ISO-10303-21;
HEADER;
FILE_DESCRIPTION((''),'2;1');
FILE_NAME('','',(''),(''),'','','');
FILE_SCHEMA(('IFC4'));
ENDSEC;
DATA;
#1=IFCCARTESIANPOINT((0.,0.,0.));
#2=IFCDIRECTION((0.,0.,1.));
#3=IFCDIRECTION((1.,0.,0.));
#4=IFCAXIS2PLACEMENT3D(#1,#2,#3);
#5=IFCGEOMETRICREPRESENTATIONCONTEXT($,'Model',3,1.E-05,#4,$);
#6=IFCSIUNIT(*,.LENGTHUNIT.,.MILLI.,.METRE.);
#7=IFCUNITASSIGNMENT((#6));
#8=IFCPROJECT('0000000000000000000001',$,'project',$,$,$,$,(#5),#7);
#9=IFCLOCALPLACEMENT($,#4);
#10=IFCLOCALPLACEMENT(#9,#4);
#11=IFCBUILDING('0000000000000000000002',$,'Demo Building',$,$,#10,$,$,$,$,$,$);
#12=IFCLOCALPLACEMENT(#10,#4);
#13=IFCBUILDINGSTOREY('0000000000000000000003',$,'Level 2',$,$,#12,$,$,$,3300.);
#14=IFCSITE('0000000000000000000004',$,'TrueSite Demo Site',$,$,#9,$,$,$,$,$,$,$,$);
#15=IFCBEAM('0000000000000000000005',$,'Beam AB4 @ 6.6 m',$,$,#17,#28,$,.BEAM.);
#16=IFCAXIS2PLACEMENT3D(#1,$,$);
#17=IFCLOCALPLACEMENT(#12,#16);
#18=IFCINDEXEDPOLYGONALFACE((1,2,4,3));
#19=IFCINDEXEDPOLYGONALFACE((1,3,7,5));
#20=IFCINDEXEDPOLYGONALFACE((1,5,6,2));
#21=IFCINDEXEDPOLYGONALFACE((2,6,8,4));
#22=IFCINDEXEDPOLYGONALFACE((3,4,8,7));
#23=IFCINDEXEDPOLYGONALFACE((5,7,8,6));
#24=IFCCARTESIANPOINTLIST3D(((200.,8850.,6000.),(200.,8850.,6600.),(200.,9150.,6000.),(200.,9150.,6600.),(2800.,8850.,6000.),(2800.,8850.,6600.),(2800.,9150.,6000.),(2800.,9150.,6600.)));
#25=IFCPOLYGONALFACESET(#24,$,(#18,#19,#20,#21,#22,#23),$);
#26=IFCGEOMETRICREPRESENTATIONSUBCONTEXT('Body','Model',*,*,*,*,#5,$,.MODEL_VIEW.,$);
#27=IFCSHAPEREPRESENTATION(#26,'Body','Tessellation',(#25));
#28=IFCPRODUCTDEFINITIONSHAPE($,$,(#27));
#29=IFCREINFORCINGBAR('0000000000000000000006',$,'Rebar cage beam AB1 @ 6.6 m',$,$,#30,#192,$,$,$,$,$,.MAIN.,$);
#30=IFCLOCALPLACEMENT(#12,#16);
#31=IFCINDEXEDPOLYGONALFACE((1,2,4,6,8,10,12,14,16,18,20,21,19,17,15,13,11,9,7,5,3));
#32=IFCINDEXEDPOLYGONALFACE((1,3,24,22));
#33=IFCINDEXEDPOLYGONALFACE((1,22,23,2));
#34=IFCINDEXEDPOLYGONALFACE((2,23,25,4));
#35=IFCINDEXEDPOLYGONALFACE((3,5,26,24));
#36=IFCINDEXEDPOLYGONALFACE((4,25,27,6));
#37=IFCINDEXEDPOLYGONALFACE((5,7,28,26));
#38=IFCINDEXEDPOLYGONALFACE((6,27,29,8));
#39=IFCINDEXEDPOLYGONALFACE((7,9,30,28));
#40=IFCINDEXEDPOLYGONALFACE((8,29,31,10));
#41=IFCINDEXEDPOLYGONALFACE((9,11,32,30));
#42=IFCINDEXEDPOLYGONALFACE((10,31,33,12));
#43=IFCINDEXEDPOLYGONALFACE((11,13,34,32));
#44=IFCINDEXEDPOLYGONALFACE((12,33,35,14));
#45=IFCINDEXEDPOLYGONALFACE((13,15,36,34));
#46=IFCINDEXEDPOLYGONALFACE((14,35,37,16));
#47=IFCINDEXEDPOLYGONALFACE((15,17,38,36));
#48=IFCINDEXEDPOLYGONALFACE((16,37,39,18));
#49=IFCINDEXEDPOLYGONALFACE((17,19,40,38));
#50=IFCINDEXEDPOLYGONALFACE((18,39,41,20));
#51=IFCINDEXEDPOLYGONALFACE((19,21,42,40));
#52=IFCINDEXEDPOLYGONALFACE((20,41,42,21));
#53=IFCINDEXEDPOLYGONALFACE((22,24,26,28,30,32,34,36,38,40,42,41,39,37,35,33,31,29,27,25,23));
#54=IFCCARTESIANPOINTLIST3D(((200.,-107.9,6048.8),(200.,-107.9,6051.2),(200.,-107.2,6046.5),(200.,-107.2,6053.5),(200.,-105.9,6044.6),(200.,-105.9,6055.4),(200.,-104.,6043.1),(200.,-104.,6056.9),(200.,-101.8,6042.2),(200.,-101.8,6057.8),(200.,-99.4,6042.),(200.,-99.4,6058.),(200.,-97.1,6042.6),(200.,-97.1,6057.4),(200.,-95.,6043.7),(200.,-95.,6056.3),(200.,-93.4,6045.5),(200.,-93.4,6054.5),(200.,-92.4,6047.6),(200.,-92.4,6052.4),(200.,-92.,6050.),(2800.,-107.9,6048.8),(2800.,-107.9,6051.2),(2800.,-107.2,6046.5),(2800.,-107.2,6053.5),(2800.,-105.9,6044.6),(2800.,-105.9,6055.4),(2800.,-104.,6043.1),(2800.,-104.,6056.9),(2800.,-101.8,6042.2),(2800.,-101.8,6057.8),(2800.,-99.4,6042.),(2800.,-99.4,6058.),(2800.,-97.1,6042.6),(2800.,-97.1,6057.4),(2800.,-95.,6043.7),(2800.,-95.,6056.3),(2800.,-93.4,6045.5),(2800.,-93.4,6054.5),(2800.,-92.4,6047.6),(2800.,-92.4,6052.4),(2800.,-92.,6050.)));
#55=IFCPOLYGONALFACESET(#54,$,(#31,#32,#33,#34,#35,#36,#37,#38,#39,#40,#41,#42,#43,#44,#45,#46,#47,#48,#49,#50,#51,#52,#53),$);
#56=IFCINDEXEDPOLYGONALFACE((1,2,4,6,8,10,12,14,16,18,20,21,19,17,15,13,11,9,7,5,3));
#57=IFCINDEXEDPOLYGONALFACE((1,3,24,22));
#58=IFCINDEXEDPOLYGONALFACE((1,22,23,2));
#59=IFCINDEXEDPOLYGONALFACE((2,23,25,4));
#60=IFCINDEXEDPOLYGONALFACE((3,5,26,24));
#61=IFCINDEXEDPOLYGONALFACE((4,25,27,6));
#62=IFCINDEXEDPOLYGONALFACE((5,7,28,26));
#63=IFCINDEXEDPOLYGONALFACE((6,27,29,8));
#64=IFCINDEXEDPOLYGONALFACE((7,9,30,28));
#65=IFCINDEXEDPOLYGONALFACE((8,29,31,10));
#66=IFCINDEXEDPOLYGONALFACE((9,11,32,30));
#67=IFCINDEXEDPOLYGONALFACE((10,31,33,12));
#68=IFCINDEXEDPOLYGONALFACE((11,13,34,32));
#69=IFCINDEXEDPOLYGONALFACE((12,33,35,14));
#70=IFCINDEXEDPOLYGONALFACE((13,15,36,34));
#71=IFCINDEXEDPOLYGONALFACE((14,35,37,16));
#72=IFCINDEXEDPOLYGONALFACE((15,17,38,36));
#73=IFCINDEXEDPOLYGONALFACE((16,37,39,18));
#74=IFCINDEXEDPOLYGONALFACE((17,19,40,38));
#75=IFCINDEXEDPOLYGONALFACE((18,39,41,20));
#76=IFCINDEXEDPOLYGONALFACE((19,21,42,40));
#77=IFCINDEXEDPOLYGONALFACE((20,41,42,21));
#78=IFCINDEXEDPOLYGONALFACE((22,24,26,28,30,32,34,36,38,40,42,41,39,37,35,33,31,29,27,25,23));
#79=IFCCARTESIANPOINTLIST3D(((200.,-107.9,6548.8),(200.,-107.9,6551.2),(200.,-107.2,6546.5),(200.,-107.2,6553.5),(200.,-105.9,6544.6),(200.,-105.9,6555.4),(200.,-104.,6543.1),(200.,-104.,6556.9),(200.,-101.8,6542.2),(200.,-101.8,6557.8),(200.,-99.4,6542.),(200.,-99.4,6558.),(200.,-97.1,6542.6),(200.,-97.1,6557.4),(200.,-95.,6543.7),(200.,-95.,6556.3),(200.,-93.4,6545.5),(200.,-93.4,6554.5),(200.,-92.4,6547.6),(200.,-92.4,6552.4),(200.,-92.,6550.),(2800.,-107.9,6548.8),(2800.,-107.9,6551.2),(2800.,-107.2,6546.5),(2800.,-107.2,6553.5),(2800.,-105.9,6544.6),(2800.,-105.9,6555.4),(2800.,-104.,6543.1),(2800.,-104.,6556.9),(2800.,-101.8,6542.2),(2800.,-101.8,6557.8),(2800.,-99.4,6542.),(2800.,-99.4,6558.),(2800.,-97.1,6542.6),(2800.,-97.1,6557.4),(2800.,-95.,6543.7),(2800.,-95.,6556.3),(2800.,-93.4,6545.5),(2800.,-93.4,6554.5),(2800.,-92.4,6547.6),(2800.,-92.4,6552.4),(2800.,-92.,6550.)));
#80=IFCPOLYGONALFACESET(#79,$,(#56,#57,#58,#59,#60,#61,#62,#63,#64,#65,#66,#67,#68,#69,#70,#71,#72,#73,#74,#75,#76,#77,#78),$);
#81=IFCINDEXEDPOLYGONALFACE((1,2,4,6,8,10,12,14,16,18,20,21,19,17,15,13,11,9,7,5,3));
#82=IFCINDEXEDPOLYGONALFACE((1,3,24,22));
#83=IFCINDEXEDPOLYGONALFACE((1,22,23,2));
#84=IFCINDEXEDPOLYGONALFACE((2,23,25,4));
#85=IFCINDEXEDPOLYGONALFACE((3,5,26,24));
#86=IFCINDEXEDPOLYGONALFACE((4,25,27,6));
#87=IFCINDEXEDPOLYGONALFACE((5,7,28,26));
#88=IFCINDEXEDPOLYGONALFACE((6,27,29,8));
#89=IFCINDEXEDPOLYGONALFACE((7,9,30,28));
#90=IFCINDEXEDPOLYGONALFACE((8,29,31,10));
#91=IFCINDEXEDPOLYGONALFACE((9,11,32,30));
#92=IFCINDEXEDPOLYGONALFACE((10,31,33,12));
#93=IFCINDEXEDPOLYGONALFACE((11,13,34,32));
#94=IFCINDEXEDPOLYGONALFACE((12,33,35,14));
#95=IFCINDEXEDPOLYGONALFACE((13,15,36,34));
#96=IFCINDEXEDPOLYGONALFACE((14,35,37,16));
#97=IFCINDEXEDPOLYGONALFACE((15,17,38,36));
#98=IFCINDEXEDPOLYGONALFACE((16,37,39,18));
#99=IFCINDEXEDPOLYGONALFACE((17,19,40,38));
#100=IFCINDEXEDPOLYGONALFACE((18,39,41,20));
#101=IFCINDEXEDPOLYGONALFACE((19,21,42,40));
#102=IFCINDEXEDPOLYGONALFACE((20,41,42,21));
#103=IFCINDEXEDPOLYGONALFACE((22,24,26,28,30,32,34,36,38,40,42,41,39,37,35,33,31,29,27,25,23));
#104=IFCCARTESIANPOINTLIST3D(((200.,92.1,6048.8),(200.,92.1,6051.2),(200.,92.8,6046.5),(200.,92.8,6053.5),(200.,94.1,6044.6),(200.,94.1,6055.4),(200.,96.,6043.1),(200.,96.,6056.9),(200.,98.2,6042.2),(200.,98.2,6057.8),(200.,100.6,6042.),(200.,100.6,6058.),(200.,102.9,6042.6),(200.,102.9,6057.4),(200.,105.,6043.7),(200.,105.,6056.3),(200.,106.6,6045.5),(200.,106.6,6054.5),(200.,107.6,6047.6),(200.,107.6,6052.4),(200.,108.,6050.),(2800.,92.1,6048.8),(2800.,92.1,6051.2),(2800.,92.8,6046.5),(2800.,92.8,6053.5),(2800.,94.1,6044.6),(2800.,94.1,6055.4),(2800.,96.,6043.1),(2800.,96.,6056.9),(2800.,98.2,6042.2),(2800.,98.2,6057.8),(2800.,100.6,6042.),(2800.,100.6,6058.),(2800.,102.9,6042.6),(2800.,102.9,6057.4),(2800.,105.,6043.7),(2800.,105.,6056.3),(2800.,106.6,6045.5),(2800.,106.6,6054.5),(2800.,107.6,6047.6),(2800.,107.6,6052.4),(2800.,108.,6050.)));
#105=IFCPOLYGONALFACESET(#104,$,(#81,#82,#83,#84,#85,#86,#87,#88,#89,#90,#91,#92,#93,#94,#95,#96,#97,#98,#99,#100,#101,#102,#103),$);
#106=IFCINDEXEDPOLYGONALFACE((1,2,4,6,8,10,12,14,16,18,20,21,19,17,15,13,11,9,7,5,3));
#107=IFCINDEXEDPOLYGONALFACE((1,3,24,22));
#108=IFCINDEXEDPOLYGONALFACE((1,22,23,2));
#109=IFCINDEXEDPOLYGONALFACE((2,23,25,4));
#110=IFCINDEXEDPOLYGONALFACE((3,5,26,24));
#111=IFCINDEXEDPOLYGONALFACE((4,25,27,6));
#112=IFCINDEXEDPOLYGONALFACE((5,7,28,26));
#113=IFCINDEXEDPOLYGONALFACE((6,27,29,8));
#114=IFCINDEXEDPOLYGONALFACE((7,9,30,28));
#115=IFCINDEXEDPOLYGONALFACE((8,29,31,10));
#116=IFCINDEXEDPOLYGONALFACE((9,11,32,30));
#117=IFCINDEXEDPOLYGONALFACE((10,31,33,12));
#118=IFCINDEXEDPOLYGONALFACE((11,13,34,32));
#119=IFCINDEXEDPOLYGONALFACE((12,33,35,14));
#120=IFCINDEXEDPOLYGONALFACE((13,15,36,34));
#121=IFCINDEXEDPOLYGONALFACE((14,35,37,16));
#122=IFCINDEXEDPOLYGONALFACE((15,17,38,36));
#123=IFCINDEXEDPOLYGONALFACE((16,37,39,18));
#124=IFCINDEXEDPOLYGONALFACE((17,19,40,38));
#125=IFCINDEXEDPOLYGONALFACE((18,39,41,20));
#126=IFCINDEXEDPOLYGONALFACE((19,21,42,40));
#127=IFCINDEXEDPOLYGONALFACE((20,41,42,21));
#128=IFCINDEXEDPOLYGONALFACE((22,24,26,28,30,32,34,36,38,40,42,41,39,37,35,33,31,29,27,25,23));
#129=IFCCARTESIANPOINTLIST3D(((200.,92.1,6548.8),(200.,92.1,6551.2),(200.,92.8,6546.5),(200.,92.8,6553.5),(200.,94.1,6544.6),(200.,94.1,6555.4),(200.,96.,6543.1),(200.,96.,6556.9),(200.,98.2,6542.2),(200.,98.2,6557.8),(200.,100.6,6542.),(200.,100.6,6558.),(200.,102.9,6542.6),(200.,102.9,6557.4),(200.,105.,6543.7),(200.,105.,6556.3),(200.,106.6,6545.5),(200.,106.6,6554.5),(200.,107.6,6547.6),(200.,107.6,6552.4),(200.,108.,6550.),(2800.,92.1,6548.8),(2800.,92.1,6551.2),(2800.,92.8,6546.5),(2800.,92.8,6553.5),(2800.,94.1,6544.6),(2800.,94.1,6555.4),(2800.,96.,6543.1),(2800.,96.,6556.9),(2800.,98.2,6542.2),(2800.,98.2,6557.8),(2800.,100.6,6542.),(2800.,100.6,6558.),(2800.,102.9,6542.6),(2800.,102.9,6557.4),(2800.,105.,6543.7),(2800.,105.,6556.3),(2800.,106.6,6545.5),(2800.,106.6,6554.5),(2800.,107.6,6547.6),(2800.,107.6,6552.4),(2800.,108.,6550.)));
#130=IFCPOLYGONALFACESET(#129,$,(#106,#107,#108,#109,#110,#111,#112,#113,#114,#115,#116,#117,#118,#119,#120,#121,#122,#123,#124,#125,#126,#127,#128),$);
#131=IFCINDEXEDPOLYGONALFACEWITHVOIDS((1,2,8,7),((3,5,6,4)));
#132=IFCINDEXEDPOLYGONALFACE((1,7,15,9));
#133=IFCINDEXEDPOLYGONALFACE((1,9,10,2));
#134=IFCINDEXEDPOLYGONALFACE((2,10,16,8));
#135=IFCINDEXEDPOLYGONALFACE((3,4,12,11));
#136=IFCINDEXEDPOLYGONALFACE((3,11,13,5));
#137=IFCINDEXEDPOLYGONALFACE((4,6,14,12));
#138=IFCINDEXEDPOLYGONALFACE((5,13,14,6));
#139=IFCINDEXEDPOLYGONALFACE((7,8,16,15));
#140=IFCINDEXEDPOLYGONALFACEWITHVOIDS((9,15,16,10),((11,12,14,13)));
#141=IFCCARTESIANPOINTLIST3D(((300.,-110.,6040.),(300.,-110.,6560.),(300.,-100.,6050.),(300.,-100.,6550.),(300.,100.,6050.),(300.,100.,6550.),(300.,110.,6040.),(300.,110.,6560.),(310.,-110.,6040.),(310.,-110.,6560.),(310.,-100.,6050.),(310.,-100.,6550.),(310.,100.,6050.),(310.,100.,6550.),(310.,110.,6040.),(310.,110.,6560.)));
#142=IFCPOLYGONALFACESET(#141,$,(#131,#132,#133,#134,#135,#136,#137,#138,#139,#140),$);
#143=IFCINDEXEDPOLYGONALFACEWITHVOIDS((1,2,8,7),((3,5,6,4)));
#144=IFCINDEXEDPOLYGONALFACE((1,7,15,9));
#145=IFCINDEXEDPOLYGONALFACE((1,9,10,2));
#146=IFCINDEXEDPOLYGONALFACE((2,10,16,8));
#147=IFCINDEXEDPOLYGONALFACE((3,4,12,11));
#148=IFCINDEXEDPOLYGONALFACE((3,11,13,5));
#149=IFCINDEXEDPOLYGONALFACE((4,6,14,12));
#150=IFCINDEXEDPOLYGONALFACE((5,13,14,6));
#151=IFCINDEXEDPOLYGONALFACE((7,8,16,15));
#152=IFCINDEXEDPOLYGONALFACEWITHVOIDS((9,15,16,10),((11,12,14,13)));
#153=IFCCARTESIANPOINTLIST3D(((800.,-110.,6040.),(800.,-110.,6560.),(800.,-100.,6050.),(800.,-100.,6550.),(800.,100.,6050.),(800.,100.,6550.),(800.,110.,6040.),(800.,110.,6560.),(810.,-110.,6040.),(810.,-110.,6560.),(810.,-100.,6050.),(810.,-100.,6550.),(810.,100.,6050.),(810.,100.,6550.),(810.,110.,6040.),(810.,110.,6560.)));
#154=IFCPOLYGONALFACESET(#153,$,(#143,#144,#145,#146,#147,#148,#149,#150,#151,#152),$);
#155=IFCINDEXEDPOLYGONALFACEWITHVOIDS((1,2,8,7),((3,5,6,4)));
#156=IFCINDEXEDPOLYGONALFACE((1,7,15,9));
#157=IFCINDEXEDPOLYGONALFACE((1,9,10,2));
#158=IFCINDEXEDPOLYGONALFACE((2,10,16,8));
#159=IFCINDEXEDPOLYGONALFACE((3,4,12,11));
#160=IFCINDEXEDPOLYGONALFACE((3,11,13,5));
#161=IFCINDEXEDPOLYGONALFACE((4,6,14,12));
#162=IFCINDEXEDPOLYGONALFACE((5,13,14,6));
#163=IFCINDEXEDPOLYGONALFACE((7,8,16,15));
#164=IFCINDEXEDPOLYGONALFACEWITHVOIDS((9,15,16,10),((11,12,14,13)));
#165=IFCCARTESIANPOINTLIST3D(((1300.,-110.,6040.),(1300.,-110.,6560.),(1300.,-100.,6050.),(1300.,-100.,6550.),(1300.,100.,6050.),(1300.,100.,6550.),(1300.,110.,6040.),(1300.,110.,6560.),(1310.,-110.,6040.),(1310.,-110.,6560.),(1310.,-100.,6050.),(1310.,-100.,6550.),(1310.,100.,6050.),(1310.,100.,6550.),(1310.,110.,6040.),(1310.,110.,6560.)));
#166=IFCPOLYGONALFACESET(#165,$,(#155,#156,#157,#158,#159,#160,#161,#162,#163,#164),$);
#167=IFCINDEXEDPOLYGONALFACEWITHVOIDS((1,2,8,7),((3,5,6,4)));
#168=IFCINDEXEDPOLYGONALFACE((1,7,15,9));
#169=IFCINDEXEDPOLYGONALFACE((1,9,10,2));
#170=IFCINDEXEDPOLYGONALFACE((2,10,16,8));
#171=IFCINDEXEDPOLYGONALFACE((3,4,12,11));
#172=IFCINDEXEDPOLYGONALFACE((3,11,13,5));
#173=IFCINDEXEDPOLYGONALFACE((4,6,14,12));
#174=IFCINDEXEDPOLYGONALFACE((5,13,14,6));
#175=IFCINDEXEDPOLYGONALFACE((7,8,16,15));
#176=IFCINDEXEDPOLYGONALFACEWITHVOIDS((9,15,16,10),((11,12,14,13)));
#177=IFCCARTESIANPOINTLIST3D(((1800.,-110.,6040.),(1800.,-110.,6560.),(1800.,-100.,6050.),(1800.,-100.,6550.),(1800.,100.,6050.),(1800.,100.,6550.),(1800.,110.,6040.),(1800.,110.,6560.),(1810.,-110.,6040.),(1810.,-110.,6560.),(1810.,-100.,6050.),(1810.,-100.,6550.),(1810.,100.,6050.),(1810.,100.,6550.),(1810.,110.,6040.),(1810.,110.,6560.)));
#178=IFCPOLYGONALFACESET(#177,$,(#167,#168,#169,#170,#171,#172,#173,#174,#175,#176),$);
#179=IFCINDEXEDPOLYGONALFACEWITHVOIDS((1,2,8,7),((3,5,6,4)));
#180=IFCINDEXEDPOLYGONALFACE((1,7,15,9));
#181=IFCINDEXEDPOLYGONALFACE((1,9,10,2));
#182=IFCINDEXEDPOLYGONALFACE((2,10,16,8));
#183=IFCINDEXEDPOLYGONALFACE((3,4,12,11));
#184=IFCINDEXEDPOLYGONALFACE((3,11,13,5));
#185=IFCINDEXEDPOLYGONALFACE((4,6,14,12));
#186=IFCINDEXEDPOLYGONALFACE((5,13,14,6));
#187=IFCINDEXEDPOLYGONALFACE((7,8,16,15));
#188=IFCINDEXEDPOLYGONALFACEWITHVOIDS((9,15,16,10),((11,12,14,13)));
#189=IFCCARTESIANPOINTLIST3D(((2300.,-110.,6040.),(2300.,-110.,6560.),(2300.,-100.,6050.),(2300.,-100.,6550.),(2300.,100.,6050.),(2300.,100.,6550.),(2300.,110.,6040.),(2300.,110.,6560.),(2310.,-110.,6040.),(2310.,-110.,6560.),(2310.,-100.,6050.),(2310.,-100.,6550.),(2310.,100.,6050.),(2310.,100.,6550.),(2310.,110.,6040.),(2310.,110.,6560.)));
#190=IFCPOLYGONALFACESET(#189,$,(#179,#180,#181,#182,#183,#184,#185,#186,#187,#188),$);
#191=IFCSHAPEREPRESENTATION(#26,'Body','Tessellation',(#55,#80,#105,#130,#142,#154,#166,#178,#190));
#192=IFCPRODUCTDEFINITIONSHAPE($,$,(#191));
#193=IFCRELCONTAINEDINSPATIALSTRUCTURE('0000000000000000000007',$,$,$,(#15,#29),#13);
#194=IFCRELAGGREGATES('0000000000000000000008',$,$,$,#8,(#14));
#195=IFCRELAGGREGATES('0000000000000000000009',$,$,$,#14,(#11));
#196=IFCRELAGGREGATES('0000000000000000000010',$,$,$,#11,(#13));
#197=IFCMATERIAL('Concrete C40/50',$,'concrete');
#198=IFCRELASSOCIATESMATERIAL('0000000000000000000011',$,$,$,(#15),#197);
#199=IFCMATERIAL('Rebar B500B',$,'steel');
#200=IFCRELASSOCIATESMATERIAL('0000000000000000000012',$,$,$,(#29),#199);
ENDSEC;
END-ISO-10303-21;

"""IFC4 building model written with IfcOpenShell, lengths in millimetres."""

from ifc_helpers import new_model, si_unit, frame, origin_with_axes, place, context, subcontext, project, spatial, rectangle, hollow_rectangle, circle, extrude, material, element, save


model = new_model("IFC4")

# Units and contexts
model_context = context("Model", 3, precision=1e-05, world=origin_with_axes())
body_context = subcontext(model_context, "Body", "Model", "MODEL_VIEW")
ifc_project = project(units=[si_unit("LENGTHUNIT", "METRE", prefix="MILLI")], contexts=[model_context])

# Site, building, storey
site_placement = place(None, origin_with_axes())
site = spatial("IfcSite", under=ifc_project, at=site_placement, Name="TrueSite Demo Site")
building_placement = place(site_placement, origin_with_axes())
building = spatial("IfcBuilding", under=site, at=building_placement, Name="Demo Building")
storey_placement = place(building_placement, origin_with_axes())
storey = spatial("IfcBuildingStorey", under=building, at=storey_placement, Name="Level 2", Elevation=3300.0)

# Shared definitions
ifc_material_1 = material(Name="Concrete C40/50", Category="concrete")

# Beam
for number, where, z_axis, x_axis, name in (
    (1, (200.0, 9000.0, 6300.0), (1.0, 0.0, 0.0), (0.0, 1.0, 0.0), "Beam AB4 @ 6.6 m"),
):
    element("IfcBeam", number, at=place(storey_placement, frame(where, z_axis=z_axis, x_axis=x_axis)), inside=storey, material=ifc_material_1, Name=name, PredefinedType="BEAM", context=body_context, shape_type="SweptSolid", body=[
        extrude(rectangle(XDim=300.0, YDim=600.0), origin_with_axes(), (0.0, 0.0, 1.0), 2600.0),
    ])

# Reinforcing bar
ifc_material_2 = material(Name="Rebar B500B", Category="steel")
for number, where, z_axis, x_axis, name in (
    (2, (200.0, 0.0, 6300.0), (1.0, 0.0, 0.0), (0.0, 1.0, 0.0), "Rebar cage beam AB1 @ 6.6 m"),
):
    element("IfcReinforcingBar", number, at=place(storey_placement, frame(where, z_axis=z_axis, x_axis=x_axis)), inside=storey, material=ifc_material_2, Name=name, PredefinedType="MAIN", context=body_context, shape_type="SweptSolid", body=[
        extrude(circle(Radius=8.0), frame((-100.0, -250.0, 0.0)), (0.0, 0.0, 1.0), 2600.0),
        extrude(circle(Radius=8.0), frame((-100.0, 250.0, 0.0)), (0.0, 0.0, 1.0), 2600.0),
        extrude(circle(Radius=8.0), frame((100.0, -250.0, 0.0)), (0.0, 0.0, 1.0), 2600.0),
        extrude(circle(Radius=8.0), frame((100.0, 250.0, 0.0)), (0.0, 0.0, 1.0), 2600.0),
        extrude(hollow_rectangle(XDim=220.0, YDim=520.0, WallThickness=10.0), frame((0.0, 0.0, 100.0)), (0.0, 0.0, 1.0), 10.0),
        extrude(hollow_rectangle(XDim=220.0, YDim=520.0, WallThickness=10.0), frame((0.0, 0.0, 600.0)), (0.0, 0.0, 1.0), 10.0),
        extrude(hollow_rectangle(XDim=220.0, YDim=520.0, WallThickness=10.0), frame((0.0, 0.0, 1100.0)), (0.0, 0.0, 1.0), 10.0),
        extrude(hollow_rectangle(XDim=220.0, YDim=520.0, WallThickness=10.0), frame((0.0, 0.0, 1600.0)), (0.0, 0.0, 1.0), 10.0),
        extrude(hollow_rectangle(XDim=220.0, YDim=520.0, WallThickness=10.0), frame((0.0, 0.0, 2100.0)), (0.0, 0.0, 1.0), 10.0),
    ])

save(model, "model.ifc")
